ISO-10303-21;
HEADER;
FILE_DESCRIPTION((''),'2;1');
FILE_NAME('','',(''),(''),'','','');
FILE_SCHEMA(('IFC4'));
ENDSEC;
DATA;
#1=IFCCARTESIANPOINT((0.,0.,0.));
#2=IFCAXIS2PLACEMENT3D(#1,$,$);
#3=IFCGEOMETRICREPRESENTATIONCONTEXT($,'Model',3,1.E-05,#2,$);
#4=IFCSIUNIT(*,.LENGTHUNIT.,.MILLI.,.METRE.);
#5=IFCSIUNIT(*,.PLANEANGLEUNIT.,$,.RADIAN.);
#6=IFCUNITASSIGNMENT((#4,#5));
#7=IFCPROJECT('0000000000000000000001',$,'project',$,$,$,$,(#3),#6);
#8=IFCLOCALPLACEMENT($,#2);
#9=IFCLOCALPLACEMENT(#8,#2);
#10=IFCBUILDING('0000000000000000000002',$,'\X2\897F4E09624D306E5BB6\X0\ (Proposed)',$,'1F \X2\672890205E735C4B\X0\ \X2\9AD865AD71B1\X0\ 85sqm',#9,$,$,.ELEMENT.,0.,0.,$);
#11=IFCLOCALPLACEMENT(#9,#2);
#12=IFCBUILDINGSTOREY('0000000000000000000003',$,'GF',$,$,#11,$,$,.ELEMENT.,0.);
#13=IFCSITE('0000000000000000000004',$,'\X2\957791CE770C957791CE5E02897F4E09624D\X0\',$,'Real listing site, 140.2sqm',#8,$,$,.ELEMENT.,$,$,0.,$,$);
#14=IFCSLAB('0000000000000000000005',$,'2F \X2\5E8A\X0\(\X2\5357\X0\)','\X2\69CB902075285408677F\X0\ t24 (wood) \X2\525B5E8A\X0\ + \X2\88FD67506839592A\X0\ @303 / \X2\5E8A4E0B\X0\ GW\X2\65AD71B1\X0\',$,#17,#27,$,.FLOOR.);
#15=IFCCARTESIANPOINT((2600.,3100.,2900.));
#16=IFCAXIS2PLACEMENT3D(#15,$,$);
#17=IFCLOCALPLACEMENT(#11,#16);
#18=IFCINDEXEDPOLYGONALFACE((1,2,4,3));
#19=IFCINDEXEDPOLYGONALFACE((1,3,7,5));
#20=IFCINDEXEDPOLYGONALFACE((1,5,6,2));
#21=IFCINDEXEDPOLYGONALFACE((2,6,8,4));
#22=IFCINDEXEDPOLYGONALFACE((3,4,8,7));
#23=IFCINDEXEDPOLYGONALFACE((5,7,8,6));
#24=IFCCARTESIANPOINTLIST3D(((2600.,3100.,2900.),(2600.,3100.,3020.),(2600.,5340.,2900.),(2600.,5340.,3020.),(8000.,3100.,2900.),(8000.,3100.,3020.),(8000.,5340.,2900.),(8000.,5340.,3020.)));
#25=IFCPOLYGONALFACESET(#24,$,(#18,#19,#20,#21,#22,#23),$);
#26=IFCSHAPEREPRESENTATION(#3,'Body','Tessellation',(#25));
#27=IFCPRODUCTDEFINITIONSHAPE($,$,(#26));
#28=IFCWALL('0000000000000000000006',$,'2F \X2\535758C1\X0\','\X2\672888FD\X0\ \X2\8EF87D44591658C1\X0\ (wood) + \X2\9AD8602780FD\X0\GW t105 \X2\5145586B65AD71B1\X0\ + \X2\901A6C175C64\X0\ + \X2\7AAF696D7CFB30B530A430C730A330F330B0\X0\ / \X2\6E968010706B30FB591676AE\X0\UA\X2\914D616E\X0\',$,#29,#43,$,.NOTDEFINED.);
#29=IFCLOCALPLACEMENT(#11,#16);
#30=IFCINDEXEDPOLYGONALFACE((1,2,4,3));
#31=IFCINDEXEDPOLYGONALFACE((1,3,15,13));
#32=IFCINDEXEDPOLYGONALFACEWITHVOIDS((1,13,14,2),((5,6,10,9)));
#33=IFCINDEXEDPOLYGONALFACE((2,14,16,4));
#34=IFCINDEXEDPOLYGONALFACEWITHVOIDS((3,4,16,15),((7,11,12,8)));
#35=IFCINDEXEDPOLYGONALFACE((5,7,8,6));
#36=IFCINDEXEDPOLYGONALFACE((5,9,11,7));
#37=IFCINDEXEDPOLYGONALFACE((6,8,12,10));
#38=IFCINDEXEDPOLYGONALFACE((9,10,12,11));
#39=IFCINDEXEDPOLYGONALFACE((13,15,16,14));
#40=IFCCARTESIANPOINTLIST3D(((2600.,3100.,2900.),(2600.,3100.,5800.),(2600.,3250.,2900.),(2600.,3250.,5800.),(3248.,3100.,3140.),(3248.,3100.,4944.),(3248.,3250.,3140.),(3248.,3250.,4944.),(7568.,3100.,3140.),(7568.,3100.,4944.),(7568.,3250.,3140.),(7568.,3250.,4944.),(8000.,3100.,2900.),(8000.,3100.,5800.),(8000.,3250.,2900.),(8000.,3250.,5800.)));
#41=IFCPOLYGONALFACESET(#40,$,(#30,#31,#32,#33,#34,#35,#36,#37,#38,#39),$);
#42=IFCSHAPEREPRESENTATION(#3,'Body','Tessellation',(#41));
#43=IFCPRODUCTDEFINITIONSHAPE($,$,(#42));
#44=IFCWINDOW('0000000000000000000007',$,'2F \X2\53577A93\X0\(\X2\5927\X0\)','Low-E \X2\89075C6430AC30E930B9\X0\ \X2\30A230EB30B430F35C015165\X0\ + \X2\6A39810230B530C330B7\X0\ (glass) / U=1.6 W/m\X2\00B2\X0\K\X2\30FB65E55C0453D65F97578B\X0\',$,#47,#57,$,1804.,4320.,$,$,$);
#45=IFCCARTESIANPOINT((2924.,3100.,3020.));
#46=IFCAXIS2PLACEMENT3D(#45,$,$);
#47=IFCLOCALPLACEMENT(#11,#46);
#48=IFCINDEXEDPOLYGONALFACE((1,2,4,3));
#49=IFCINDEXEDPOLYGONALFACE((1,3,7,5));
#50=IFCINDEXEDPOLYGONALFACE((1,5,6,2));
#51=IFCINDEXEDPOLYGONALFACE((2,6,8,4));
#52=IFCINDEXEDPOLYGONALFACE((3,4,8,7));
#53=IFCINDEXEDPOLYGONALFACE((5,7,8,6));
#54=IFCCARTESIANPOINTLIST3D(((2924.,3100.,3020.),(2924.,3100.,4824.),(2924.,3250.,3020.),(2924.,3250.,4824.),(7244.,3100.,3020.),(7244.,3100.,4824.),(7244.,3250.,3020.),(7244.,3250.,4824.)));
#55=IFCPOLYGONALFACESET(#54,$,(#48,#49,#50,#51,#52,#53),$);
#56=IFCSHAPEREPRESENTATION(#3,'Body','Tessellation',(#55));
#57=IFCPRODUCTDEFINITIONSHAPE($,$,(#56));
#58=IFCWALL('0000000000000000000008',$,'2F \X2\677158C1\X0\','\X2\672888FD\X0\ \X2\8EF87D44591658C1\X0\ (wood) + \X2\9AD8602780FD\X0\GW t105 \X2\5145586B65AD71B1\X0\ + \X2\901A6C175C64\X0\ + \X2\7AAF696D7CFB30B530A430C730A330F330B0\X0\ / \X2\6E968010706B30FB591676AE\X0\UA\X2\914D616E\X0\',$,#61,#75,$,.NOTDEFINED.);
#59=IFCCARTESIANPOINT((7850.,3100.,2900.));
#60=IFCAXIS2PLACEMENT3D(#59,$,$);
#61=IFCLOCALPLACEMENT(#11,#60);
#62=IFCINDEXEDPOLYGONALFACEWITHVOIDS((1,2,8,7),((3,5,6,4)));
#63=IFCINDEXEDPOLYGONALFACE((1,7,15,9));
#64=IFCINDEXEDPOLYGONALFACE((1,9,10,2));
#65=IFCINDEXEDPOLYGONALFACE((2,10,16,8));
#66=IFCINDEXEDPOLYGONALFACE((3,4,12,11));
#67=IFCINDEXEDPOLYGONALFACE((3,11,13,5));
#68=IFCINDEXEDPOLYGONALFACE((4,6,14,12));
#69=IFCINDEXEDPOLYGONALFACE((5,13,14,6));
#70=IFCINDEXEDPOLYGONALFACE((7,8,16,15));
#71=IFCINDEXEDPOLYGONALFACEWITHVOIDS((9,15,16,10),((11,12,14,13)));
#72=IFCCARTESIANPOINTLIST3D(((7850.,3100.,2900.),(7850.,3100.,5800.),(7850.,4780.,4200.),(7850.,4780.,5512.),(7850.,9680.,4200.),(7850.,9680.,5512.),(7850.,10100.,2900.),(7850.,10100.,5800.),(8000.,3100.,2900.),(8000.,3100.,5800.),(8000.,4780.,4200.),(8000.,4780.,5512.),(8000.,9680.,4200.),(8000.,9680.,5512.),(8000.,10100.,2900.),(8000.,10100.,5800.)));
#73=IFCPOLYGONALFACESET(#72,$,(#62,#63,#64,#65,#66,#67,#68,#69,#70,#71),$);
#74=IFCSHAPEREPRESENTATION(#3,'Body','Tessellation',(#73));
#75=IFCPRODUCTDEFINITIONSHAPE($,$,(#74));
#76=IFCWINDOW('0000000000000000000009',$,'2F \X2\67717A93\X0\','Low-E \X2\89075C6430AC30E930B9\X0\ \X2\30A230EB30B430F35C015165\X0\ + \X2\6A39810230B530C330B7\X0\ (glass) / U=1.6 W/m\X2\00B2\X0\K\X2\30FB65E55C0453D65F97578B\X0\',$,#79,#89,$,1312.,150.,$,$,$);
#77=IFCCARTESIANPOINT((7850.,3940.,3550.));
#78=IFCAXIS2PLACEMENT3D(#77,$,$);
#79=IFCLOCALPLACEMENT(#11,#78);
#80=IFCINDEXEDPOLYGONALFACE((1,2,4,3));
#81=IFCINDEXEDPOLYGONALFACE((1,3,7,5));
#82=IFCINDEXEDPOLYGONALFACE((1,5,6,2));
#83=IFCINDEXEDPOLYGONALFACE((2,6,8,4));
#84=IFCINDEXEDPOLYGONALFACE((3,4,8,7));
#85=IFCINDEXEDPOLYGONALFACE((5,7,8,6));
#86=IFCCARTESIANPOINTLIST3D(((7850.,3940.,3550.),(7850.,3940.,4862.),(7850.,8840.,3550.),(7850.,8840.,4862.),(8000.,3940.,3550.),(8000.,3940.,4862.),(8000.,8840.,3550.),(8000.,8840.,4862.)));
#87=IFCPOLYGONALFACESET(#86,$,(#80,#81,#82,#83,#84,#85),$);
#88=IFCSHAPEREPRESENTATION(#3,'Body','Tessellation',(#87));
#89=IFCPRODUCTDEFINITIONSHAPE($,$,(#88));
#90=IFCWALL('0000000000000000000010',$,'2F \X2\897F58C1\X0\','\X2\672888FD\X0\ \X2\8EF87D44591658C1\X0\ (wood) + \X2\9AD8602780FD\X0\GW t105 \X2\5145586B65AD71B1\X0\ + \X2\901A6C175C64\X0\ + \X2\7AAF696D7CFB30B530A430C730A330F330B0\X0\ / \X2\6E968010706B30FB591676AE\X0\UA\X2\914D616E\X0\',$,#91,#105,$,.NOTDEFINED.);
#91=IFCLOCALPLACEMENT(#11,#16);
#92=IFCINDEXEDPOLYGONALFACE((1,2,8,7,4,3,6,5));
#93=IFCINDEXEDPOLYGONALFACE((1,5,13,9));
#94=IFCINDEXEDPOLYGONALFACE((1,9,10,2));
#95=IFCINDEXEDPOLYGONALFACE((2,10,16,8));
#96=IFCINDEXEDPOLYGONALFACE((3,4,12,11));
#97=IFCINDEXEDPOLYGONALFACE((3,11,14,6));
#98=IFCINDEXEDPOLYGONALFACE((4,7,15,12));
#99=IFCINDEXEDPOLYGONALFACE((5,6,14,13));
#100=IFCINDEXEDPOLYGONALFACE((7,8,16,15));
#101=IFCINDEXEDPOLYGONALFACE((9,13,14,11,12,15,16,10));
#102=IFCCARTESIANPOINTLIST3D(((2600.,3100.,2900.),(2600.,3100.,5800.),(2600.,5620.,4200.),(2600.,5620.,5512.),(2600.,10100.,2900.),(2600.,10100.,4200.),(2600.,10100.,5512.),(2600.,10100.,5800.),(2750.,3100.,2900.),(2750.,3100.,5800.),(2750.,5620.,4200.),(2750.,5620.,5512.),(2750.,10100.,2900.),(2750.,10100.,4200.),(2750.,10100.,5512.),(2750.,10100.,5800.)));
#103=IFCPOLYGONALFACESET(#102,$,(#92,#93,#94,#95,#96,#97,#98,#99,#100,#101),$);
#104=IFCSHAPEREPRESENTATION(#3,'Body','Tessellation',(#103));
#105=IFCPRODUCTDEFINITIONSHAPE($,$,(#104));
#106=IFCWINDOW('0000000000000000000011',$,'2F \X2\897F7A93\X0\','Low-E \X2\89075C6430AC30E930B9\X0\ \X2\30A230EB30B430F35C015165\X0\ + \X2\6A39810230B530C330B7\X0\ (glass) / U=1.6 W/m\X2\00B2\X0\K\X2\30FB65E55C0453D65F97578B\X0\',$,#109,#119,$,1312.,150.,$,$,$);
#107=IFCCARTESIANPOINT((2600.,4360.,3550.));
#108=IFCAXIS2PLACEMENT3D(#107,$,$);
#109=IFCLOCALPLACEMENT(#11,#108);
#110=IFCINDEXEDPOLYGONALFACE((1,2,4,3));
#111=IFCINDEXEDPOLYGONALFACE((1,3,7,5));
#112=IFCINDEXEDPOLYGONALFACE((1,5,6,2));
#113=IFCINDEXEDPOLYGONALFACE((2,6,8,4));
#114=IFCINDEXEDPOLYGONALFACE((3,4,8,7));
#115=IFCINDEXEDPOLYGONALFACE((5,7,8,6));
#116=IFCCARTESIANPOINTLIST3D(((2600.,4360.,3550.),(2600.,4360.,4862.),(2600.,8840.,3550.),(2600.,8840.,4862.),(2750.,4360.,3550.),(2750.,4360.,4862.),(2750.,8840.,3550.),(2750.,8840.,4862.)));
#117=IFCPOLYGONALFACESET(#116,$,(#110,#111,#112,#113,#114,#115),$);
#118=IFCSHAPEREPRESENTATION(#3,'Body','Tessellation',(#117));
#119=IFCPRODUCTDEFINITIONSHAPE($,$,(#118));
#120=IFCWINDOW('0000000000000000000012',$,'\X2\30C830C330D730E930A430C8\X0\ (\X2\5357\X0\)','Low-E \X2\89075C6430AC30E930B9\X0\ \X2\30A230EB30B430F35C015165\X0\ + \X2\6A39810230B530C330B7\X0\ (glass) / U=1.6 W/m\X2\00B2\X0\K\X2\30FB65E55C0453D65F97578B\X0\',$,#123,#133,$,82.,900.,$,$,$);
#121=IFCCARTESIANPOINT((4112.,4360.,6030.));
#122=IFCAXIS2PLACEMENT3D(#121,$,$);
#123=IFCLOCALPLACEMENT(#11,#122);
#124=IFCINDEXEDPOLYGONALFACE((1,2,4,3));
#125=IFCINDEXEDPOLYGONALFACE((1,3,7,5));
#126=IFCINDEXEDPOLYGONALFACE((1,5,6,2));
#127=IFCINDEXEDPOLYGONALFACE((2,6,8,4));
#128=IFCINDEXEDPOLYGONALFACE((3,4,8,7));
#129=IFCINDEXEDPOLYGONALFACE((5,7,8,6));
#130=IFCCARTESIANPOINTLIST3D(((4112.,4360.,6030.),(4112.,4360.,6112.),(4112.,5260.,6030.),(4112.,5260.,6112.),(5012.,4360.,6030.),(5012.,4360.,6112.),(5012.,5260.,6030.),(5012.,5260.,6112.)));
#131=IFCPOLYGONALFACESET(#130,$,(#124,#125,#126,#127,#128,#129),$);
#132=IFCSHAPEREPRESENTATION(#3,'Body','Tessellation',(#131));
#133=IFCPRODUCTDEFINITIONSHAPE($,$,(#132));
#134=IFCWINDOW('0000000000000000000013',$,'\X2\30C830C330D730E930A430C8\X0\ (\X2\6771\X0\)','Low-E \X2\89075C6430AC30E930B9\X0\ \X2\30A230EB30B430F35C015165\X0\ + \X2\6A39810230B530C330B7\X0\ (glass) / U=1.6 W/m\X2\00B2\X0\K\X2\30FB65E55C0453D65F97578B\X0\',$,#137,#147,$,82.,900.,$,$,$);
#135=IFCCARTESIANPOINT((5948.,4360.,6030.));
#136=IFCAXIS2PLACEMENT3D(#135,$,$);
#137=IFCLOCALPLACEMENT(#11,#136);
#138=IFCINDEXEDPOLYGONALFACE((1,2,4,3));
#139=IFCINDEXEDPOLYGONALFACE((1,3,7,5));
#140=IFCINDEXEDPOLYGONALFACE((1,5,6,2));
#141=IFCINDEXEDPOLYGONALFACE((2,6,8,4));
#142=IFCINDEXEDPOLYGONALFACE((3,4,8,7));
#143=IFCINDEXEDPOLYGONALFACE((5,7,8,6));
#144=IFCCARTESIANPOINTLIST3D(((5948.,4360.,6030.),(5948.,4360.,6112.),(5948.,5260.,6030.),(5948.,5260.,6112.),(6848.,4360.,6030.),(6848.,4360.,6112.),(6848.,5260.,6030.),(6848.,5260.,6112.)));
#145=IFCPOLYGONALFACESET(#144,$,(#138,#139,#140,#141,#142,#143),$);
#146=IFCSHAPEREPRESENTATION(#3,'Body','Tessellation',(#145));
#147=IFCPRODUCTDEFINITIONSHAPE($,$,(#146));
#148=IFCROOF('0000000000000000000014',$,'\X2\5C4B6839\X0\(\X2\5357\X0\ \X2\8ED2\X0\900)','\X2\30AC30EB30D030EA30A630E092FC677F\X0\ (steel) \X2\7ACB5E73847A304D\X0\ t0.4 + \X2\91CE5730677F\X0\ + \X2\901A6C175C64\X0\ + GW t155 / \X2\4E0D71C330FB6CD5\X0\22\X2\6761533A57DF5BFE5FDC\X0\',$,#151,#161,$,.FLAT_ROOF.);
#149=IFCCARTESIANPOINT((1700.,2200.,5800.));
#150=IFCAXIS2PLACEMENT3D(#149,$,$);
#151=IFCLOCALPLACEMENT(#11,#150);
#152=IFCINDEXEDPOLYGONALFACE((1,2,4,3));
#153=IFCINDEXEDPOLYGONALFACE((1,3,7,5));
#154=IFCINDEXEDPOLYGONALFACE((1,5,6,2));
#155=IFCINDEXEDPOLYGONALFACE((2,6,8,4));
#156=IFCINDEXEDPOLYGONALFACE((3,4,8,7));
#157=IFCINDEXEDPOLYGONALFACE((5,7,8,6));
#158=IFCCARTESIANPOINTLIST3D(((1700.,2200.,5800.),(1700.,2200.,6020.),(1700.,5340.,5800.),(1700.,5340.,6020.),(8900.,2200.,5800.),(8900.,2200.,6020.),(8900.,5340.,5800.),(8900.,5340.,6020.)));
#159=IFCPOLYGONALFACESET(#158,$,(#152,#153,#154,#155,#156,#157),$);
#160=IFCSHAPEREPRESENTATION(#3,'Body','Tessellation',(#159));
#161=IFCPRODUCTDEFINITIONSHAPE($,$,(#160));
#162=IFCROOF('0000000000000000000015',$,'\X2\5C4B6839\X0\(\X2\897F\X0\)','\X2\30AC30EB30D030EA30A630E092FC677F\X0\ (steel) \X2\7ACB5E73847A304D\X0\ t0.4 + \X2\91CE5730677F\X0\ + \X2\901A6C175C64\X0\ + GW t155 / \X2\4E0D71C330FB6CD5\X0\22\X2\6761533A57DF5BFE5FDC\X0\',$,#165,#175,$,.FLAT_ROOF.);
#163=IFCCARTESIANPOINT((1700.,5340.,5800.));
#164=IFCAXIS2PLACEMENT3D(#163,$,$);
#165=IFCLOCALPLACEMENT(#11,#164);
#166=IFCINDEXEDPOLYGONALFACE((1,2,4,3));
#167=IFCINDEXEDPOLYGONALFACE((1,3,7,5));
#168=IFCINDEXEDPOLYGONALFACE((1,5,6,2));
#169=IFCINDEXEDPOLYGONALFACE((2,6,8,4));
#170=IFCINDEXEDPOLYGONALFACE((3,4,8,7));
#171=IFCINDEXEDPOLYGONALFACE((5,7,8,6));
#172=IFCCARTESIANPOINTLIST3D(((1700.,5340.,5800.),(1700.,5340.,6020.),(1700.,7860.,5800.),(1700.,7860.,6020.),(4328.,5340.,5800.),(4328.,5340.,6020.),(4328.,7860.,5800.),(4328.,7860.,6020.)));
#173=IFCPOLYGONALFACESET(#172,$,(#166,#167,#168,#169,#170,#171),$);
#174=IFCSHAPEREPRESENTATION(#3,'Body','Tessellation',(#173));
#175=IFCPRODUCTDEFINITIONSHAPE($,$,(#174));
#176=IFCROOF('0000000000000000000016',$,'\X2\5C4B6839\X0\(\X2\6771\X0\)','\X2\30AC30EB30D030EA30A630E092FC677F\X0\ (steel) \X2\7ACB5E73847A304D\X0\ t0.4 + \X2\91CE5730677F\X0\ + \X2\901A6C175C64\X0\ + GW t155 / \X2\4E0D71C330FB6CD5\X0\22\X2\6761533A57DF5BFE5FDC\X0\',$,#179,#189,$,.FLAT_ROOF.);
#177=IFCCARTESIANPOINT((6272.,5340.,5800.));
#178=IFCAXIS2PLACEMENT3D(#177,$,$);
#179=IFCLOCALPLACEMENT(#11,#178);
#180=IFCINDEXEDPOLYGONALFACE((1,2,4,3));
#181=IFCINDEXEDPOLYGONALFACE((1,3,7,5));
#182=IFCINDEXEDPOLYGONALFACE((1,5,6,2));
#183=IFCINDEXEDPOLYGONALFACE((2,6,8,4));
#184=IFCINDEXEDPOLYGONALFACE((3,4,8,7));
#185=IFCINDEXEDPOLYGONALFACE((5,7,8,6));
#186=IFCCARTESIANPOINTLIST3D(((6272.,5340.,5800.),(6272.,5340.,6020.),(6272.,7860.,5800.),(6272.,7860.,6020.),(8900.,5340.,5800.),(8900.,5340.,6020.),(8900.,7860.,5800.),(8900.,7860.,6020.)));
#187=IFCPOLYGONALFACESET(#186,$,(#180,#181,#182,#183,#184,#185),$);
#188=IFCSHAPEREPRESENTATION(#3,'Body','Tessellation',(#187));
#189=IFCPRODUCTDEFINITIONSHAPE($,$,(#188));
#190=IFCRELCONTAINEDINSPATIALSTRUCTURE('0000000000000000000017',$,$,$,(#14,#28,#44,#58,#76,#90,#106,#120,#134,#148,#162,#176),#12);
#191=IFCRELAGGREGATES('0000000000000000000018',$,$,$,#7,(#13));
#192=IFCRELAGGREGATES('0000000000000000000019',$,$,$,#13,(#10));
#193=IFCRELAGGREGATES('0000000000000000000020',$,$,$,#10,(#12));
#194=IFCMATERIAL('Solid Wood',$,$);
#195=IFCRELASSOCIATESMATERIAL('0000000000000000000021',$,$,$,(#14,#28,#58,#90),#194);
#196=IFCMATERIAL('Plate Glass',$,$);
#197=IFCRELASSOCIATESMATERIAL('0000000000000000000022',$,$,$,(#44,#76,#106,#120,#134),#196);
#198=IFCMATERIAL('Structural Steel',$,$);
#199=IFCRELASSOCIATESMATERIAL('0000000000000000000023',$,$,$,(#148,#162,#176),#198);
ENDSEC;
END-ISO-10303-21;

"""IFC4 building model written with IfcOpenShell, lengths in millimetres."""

from ifc_helpers import new_model, si_unit, frame, frame_2d, origin, place, context, project, spatial, rectangle, extrude, material, element, fill, save


model = new_model("IFC4")

# Units and contexts
model_context = context("Model", 3, precision=1e-05, world=origin())
ifc_project = project(units=[si_unit("LENGTHUNIT", "METRE", prefix="MILLI"), si_unit("PLANEANGLEUNIT", "RADIAN")], contexts=[model_context])

# Site, building, storey
site_placement = place(None, origin())
site = spatial("IfcSite", under=ifc_project, at=site_placement, Name="長野県長野市西三才", ObjectType="Real listing site, 140.2sqm", CompositionType="ELEMENT", RefElevation=0.0)
building_placement = place(site_placement, origin())
building = spatial("IfcBuilding", under=site, at=building_placement, Name="西三才の家 (Proposed)", ObjectType="1F 木造平屋 高断熱 85sqm", CompositionType="ELEMENT", ElevationOfRefHeight=0.0, ElevationOfTerrain=0.0)
storey_placement = place(building_placement, origin())
storey = spatial("IfcBuildingStorey", under=building, at=storey_placement, Name="GF", CompositionType="ELEMENT", Elevation=0.0)

# Slab
ifc_material_1 = material(Name="Solid Wood")
slab_placement = place(storey_placement, frame((2600.0, 3100.0, 2900.0)))
element("IfcSlab", 1, at=slab_placement, inside=storey, material=ifc_material_1, Name="2F 床(南)", Description="構造用合板 t24 (wood) 剛床 + 製材根太 @303 / 床下 GW断熱", PredefinedType="FLOOR", context=model_context, shape_type="SweptSolid", body=[
    extrude(rectangle(XDim=5400.0, YDim=2240.0, at=frame_2d((2700.0, 1120.0))), frame((2600.0, 3100.0, 2900.0)), (0.0, 0.0, 1.0), 120.0),
])

# Walls, openings, windows
wall_1_placement = place(storey_placement, frame((2600.0, 3100.0, 2900.0)))
wall_1 = element("IfcWall", 2, at=wall_1_placement, inside=storey, material=ifc_material_1, Name="2F 南壁", Description="木製 軸組外壁 (wood) + 高性能GW t105 充填断熱 + 通気層 + 窯業系サイディング / 準耐火・外皮UA配慮", PredefinedType="NOTDEFINED", context=model_context, shape_type="SweptSolid", body=[
    extrude(rectangle(XDim=5400.0, YDim=150.0, at=frame_2d((2700.0, 75.0))), frame((2600.0, 3100.0, 2900.0)), (0.0, 0.0, 1.0), 2900.0),
])
opening_1_placement = place(storey_placement, frame((2924.0, 3100.0, 3020.0)))
opening_1 = element("IfcOpeningElement", 3, at=opening_1_placement, cuts=wall_1, PredefinedType="NOTDEFINED", context=model_context, shape_type="SweptSolid", body=[
    extrude(rectangle(XDim=4320.0, YDim=150.0, at=frame_2d((2160.0, 75.0))), frame((2924.0, 3100.0, 3020.0)), (0.0, 0.0, 1.0), 1804.0),
])
ifc_material_2 = material(Name="Plate Glass")
window_1_placement = place(storey_placement, frame((2924.0, 3100.0, 3020.0)))
window_1 = element("IfcWindow", 4, at=window_1_placement, inside=storey, material=ifc_material_2, Name="2F 南窓(大)", Description="Low-E 複層ガラス アルゴン封入 + 樹脂サッシ (glass) / U=1.6 W/m²K・日射取得型", OverallHeight=1804.0, OverallWidth=4320.0, context=model_context, shape_type="SweptSolid", body=[
    extrude(rectangle(XDim=4320.0, YDim=150.0, at=frame_2d((2160.0, 75.0))), frame((2924.0, 3100.0, 3020.0)), (0.0, 0.0, 1.0), 1804.0),
])
fill(opening_1, window_1)
wall_2_placement = place(storey_placement, frame((7850.0, 3100.0, 2900.0)))
wall_2 = element("IfcWall", 5, at=wall_2_placement, inside=storey, material=ifc_material_1, Name="2F 東壁", Description="木製 軸組外壁 (wood) + 高性能GW t105 充填断熱 + 通気層 + 窯業系サイディング / 準耐火・外皮UA配慮", PredefinedType="NOTDEFINED", context=model_context, shape_type="SweptSolid", body=[
    extrude(rectangle(XDim=150.0, YDim=7000.0, at=frame_2d((75.0, 3500.0))), frame((7850.0, 3100.0, 2900.0)), (0.0, 0.0, 1.0), 2900.0),
])
opening_2_placement = place(storey_placement, frame((7850.0, 3940.0, 3550.0)))
opening_2 = element("IfcOpeningElement", 6, at=opening_2_placement, cuts=wall_2, PredefinedType="NOTDEFINED", context=model_context, shape_type="SweptSolid", body=[
    extrude(rectangle(XDim=150.0, YDim=4900.0, at=frame_2d((75.0, 2450.0))), frame((7850.0, 3940.0, 3550.0)), (0.0, 0.0, 1.0), 1312.0),
])
window_2_placement = place(storey_placement, frame((7850.0, 3940.0, 3550.0)))
window_2 = element("IfcWindow", 7, at=window_2_placement, inside=storey, material=ifc_material_2, Name="2F 東窓", Description="Low-E 複層ガラス アルゴン封入 + 樹脂サッシ (glass) / U=1.6 W/m²K・日射取得型", OverallHeight=1312.0, OverallWidth=150.0, context=model_context, shape_type="SweptSolid", body=[
    extrude(rectangle(XDim=150.0, YDim=4900.0, at=frame_2d((75.0, 2450.0))), frame((7850.0, 3940.0, 3550.0)), (0.0, 0.0, 1.0), 1312.0),
])
fill(opening_2, window_2)
wall_3_placement = place(storey_placement, frame((2600.0, 3100.0, 2900.0)))
wall_3 = element("IfcWall", 8, at=wall_3_placement, inside=storey, material=ifc_material_1, Name="2F 西壁", Description="木製 軸組外壁 (wood) + 高性能GW t105 充填断熱 + 通気層 + 窯業系サイディング / 準耐火・外皮UA配慮", PredefinedType="NOTDEFINED", context=model_context, shape_type="SweptSolid", body=[
    extrude(rectangle(XDim=150.0, YDim=7000.0, at=frame_2d((75.0, 3500.0))), frame((2600.0, 3100.0, 2900.0)), (0.0, 0.0, 1.0), 2900.0),
])
opening_3_placement = place(storey_placement, frame((2600.0, 4360.0, 3550.0)))
opening_3 = element("IfcOpeningElement", 9, at=opening_3_placement, cuts=wall_3, PredefinedType="NOTDEFINED", context=model_context, shape_type="SweptSolid", body=[
    extrude(rectangle(XDim=150.0, YDim=4480.0, at=frame_2d((75.0, 2240.0))), frame((2600.0, 4360.0, 3550.0)), (0.0, 0.0, 1.0), 1312.0),
])
window_3_placement = place(storey_placement, frame((2600.0, 4360.0, 3550.0)))
window_3 = element("IfcWindow", 10, at=window_3_placement, inside=storey, material=ifc_material_2, Name="2F 西窓", Description="Low-E 複層ガラス アルゴン封入 + 樹脂サッシ (glass) / U=1.6 W/m²K・日射取得型", OverallHeight=1312.0, OverallWidth=150.0, context=model_context, shape_type="SweptSolid", body=[
    extrude(rectangle(XDim=150.0, YDim=4480.0, at=frame_2d((75.0, 2240.0))), frame((2600.0, 4360.0, 3550.0)), (0.0, 0.0, 1.0), 1312.0),
])
fill(opening_3, window_3)

# Windows
window_4_placement = place(storey_placement, frame((4112.0, 4360.0, 6030.0)))
element("IfcWindow", 11, at=window_4_placement, inside=storey, material=ifc_material_2, Name="トップライト (南)", Description="Low-E 複層ガラス アルゴン封入 + 樹脂サッシ (glass) / U=1.6 W/m²K・日射取得型", OverallHeight=82.0, OverallWidth=900.0, context=model_context, shape_type="SweptSolid", body=[
    extrude(rectangle(XDim=900.0, YDim=900.0, at=frame_2d((450.0, 450.0))), frame((4112.0, 4360.0, 6030.0)), (0.0, 0.0, 1.0), 82.0),
])
window_5_placement = place(storey_placement, frame((5948.0, 4360.0, 6030.0)))
element("IfcWindow", 12, at=window_5_placement, inside=storey, material=ifc_material_2, Name="トップライト (東)", Description="Low-E 複層ガラス アルゴン封入 + 樹脂サッシ (glass) / U=1.6 W/m²K・日射取得型", OverallHeight=82.0, OverallWidth=900.0, context=model_context, shape_type="SweptSolid", body=[
    extrude(rectangle(XDim=900.0, YDim=900.0, at=frame_2d((450.0, 450.0))), frame((5948.0, 4360.0, 6030.0)), (0.0, 0.0, 1.0), 82.0),
])

# Roofs
ifc_material_3 = material(Name="Structural Steel")
roof_1_placement = place(storey_placement, frame((1700.0, 2200.0, 5800.0)))
element("IfcRoof", 13, at=roof_1_placement, inside=storey, material=ifc_material_3, Name="屋根(南 軒900)", Description="ガルバリウム鋼板 (steel) 立平葺き t0.4 + 野地板 + 通気層 + GW t155 / 不燃・法22条区域対応", PredefinedType="FLAT_ROOF", context=model_context, shape_type="SweptSolid", body=[
    extrude(rectangle(XDim=7200.0, YDim=3140.0, at=frame_2d((3600.0, 1570.0))), frame((1700.0, 2200.0, 5800.0)), (0.0, 0.0, 1.0), 220.0),
])
roof_2_placement = place(storey_placement, frame((1700.0, 5340.0, 5800.0)))
element("IfcRoof", 14, at=roof_2_placement, inside=storey, material=ifc_material_3, Name="屋根(西)", Description="ガルバリウム鋼板 (steel) 立平葺き t0.4 + 野地板 + 通気層 + GW t155 / 不燃・法22条区域対応", PredefinedType="FLAT_ROOF", context=model_context, shape_type="SweptSolid", body=[
    extrude(rectangle(XDim=2628.0, YDim=2520.0, at=frame_2d((1314.0, 1260.0))), frame((1700.0, 5340.0, 5800.0)), (0.0, 0.0, 1.0), 220.0),
])
roof_3_placement = place(storey_placement, frame((6272.0, 5340.0, 5800.0)))
element("IfcRoof", 15, at=roof_3_placement, inside=storey, material=ifc_material_3, Name="屋根(東)", Description="ガルバリウム鋼板 (steel) 立平葺き t0.4 + 野地板 + 通気層 + GW t155 / 不燃・法22条区域対応", PredefinedType="FLAT_ROOF", context=model_context, shape_type="SweptSolid", body=[
    extrude(rectangle(XDim=2628.0, YDim=2520.0, at=frame_2d((1314.0, 1260.0))), frame((6272.0, 5340.0, 5800.0)), (0.0, 0.0, 1.0), 220.0),
])

save(model, "model.ifc")
